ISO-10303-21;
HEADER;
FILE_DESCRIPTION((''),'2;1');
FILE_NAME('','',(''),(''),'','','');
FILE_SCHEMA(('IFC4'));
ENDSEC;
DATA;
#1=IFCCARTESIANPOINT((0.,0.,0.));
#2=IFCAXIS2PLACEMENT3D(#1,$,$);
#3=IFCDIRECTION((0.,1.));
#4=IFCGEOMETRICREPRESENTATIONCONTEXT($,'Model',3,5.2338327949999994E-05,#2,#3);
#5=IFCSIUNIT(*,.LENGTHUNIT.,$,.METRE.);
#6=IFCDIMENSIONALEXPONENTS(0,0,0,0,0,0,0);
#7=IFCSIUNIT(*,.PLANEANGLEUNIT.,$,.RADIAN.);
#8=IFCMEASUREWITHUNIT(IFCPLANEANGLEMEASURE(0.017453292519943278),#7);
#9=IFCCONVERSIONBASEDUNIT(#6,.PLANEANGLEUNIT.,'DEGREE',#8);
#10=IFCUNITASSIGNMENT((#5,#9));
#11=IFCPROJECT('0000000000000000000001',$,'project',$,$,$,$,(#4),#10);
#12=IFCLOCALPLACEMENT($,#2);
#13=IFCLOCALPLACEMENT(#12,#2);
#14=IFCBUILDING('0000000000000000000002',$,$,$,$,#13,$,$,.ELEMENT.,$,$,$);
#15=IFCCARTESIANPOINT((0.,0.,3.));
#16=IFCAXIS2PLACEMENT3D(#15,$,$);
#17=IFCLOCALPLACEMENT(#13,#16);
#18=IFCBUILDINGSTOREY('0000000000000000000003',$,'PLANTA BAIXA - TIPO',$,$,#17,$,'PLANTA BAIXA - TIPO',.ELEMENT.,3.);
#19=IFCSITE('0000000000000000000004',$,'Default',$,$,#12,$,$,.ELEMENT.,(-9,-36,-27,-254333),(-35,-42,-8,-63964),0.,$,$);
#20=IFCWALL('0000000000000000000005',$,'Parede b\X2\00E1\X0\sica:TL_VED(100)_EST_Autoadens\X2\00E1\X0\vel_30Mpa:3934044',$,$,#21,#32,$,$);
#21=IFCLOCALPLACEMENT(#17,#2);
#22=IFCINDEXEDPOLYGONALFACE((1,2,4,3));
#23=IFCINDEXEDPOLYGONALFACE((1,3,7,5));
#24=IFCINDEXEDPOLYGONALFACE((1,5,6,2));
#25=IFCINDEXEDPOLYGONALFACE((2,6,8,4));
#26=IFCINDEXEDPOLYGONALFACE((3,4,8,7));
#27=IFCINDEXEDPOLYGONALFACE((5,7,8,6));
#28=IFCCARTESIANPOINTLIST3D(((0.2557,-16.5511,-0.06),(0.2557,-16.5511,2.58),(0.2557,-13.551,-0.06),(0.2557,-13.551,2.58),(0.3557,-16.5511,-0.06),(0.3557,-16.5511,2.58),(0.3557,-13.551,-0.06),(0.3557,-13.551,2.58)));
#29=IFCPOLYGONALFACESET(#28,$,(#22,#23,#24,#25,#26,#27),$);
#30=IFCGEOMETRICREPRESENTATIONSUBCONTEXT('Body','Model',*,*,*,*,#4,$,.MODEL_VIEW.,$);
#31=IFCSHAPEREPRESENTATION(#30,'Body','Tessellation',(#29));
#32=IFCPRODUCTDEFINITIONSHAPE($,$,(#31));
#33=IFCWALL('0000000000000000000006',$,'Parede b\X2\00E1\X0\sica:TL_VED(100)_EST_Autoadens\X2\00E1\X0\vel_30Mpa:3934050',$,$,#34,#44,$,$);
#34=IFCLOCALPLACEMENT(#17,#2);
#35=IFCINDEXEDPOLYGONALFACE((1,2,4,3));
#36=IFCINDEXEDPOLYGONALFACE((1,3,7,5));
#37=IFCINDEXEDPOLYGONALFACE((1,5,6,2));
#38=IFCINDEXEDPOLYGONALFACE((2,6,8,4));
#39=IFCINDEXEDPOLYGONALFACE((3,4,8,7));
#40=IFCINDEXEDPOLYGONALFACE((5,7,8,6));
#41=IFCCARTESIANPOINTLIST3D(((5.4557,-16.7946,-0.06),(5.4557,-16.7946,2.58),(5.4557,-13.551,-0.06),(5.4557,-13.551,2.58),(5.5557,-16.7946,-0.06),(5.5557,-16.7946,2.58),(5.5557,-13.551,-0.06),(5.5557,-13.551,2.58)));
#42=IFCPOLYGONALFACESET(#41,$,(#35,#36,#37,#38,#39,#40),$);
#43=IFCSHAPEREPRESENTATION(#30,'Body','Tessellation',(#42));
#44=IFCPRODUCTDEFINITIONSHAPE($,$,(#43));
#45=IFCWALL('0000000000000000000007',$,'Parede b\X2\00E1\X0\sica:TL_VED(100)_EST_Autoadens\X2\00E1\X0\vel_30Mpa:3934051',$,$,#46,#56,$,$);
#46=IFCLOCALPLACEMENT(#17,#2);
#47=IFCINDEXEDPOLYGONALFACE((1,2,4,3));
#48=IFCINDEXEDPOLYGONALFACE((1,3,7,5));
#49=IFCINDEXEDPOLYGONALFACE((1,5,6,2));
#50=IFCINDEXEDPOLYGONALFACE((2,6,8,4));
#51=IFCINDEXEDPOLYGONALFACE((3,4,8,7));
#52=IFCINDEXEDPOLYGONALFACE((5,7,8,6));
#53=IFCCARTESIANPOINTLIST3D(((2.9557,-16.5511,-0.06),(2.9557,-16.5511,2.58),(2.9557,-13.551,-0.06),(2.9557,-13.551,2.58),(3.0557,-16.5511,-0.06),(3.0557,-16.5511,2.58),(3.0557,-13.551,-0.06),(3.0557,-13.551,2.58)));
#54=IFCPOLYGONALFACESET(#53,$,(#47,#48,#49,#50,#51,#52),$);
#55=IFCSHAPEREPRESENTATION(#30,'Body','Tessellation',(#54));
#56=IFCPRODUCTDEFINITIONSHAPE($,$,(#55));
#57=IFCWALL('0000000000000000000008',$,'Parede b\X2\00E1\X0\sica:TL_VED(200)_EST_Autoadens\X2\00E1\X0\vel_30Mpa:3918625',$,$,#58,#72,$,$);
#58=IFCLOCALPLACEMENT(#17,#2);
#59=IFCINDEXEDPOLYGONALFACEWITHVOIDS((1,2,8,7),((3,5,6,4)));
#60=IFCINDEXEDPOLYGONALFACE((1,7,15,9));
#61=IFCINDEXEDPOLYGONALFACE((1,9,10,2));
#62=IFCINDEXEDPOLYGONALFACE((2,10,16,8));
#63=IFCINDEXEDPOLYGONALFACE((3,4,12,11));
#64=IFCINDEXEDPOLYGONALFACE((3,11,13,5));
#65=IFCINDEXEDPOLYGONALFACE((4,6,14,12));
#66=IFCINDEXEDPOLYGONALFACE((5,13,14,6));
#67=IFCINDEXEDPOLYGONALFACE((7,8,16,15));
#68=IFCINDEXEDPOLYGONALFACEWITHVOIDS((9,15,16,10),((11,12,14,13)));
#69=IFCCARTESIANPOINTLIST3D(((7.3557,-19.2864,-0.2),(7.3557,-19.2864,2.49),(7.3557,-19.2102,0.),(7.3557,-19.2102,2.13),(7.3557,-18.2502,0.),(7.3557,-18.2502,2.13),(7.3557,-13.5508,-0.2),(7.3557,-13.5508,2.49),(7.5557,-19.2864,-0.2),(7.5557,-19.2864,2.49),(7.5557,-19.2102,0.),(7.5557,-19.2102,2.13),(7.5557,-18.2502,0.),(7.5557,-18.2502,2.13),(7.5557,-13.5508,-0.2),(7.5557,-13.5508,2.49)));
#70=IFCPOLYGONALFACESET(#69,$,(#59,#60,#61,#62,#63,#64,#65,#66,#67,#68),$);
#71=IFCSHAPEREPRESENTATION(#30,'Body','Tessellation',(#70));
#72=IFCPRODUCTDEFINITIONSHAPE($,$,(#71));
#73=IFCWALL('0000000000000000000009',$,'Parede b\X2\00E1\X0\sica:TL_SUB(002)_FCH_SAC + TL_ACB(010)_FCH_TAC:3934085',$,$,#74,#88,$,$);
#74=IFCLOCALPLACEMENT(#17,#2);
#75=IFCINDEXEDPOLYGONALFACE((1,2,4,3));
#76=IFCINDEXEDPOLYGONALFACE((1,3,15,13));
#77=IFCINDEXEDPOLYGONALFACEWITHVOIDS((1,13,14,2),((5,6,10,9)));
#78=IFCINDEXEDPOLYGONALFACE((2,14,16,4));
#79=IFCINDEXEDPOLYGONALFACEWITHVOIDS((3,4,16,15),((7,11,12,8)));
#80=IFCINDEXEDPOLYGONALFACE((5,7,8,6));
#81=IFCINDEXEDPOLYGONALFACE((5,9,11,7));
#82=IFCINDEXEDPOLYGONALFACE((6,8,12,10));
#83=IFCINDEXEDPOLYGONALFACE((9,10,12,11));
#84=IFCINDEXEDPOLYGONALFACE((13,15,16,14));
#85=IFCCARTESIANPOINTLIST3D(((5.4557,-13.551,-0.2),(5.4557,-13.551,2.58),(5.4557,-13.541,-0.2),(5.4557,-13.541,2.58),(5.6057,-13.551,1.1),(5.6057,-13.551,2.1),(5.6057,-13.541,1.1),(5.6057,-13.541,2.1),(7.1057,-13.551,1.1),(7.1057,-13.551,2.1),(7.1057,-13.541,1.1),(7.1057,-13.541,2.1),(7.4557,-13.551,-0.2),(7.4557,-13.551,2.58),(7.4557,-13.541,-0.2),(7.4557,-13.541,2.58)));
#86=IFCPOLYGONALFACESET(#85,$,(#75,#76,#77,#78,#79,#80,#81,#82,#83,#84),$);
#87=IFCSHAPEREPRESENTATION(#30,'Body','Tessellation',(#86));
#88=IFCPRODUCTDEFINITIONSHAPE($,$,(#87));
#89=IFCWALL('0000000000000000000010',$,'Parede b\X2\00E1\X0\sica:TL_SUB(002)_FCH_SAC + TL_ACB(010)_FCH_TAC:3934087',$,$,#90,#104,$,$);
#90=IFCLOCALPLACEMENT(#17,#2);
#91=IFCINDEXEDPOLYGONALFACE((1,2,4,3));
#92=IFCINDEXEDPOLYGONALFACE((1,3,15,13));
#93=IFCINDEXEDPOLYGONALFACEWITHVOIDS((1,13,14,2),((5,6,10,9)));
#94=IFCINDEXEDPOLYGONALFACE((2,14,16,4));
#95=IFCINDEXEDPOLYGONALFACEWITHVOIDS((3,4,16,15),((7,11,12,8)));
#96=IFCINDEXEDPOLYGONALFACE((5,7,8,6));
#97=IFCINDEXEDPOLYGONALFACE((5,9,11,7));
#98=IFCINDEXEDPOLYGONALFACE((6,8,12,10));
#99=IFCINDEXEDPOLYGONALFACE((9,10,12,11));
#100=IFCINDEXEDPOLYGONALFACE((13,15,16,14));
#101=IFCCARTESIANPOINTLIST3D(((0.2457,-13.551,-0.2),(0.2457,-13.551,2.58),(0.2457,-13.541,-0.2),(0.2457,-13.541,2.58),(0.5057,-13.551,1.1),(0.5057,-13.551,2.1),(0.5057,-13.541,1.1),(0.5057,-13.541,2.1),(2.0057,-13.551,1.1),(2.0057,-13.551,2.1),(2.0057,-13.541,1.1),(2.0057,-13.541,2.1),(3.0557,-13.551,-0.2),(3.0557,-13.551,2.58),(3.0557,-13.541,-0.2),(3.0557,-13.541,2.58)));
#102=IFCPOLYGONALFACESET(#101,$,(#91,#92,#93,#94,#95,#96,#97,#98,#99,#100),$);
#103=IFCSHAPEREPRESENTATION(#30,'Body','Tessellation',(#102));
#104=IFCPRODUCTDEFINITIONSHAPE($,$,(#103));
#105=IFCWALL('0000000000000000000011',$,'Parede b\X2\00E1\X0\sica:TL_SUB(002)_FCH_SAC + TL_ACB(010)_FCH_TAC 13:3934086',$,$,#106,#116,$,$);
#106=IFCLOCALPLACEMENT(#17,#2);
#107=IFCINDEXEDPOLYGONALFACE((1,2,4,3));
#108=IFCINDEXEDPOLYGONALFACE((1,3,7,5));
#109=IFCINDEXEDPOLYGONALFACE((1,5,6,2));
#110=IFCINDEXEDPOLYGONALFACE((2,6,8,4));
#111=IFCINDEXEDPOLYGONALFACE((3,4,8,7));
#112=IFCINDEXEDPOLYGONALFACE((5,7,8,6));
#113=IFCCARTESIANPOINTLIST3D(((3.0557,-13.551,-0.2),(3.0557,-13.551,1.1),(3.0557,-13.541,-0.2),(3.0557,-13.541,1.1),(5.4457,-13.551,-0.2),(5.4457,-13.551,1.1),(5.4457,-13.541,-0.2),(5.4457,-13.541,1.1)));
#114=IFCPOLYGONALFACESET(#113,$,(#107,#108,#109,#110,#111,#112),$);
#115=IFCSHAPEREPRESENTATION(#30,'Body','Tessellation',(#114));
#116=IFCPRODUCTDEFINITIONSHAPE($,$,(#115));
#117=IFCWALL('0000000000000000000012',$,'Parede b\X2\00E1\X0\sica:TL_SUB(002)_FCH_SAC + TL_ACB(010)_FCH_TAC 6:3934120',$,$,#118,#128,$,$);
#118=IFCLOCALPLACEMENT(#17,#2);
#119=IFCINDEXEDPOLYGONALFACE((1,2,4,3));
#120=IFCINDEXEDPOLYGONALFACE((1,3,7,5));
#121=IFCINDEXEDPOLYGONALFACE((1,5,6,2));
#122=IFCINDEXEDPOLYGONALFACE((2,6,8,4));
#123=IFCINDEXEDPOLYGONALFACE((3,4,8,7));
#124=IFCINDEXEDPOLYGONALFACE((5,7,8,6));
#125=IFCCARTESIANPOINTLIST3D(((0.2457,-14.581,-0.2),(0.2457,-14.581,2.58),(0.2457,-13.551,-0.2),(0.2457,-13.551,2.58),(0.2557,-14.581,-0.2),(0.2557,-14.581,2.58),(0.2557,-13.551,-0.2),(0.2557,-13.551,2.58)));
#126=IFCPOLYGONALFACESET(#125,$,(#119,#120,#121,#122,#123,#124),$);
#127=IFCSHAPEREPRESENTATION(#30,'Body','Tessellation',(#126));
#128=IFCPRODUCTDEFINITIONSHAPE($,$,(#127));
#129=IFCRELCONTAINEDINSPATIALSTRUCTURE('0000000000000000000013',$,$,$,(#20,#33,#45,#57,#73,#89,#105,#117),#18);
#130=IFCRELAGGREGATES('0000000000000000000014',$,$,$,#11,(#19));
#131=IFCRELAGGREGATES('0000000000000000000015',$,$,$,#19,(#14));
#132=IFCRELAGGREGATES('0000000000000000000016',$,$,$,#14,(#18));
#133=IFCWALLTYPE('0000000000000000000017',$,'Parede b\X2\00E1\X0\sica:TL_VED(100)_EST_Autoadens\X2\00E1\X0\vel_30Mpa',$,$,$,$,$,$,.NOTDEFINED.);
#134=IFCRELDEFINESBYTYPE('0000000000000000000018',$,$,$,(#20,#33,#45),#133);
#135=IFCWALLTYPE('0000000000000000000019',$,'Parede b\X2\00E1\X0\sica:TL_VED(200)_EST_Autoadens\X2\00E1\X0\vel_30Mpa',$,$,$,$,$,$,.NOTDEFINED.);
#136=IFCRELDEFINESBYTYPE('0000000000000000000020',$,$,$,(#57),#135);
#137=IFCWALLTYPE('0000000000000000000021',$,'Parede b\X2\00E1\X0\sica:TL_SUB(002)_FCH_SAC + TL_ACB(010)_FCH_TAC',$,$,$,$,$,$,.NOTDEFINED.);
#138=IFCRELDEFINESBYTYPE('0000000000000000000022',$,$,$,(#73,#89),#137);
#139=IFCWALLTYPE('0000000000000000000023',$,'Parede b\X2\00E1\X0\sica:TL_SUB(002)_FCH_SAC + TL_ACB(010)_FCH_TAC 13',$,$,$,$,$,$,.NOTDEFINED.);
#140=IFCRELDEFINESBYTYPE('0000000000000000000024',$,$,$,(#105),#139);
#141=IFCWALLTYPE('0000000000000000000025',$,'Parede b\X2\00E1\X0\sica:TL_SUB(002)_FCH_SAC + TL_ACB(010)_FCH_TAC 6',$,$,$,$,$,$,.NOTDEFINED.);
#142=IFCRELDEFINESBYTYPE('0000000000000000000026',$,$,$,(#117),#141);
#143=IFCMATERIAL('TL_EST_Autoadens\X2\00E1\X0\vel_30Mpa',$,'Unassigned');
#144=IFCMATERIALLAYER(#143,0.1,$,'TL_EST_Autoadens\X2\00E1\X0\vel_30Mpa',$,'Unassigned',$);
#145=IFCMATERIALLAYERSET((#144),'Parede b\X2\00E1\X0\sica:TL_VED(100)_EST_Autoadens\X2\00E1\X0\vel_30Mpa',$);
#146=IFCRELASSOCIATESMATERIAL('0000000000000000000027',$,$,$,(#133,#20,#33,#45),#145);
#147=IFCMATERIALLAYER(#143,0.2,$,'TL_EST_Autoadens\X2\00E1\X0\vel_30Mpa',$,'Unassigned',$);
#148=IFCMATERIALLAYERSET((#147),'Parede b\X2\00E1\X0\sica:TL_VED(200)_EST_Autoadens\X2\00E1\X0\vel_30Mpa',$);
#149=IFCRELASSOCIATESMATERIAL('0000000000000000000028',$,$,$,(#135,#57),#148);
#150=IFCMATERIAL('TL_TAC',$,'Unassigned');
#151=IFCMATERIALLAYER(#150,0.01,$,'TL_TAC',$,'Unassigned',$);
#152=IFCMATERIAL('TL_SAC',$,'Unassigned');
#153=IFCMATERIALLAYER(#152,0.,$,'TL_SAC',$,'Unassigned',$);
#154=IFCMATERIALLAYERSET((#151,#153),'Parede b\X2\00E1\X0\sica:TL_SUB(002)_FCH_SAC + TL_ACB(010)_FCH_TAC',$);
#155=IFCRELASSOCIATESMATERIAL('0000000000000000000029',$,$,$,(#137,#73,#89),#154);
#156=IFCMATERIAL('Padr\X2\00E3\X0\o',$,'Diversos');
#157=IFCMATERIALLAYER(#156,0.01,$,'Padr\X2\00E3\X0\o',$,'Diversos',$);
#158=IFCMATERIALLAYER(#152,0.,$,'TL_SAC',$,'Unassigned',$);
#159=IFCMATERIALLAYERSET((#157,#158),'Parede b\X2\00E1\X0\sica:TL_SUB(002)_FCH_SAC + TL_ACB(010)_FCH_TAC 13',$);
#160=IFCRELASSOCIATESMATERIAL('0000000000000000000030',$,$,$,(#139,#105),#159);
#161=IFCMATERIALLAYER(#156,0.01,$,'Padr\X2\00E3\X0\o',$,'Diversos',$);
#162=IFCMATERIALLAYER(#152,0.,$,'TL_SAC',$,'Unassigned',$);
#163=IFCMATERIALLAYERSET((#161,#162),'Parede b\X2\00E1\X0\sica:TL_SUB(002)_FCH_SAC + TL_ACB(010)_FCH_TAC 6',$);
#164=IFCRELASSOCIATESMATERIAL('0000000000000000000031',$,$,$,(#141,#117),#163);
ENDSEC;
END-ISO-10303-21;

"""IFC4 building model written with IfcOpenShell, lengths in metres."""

from ifc_helpers import new_model, entity, si_unit, converted_unit, direction, frame, frame_2d, origin, place, context, subcontext, project, spatial, rectangle, extrude, material, layer, layer_set, layer_usage, type_object, element, save


model = new_model("IFC4")

# Units and contexts
model_context = context("Model", 3, precision=5.2338327949999994e-05, world=origin(), true_north=direction((0.0, 1.0)))
body_context = subcontext(model_context, "Body", "Model", "MODEL_VIEW")
ifc_project = project(units=[si_unit("LENGTHUNIT", "METRE"), converted_unit("PLANEANGLEUNIT", "DEGREE", entity("IfcPlaneAngleMeasure", 0.017453292519943278), si_unit("PLANEANGLEUNIT", "RADIAN"), dimensions=[0, 0, 0, 0, 0, 0, 0])], contexts=[model_context])

# Site, building, storey
site_placement = place(None, frame((0.0, 0.0, 0.0)))
site = spatial("IfcSite", under=ifc_project, at=site_placement, Name="Default", CompositionType="ELEMENT", RefLatitude=(-9, -36, -27, -254333), RefLongitude=(-35, -42, -8, -63964), RefElevation=0.0)
building_placement = place(site_placement, origin())
building = spatial("IfcBuilding", under=site, at=building_placement, CompositionType="ELEMENT")
storey_placement = place(building_placement, frame((0.0, 0.0, 3.0)))
storey = spatial("IfcBuildingStorey", under=building, at=storey_placement, Name="PLANTA BAIXA - TIPO", LongName="PLANTA BAIXA - TIPO", CompositionType="ELEMENT", Elevation=3.0)

# Walls
ifc_material_1 = material(Name="TL_EST_Autoadensável_30Mpa", Category="Unassigned")
ifc_layer_1 = layer(ifc_material_1, 0.1, Name="TL_EST_Autoadensável_30Mpa", Category="Unassigned")
ifc_layer_set_1 = layer_set([ifc_layer_1], Name="Parede básica:TL_VED(100)_EST_Autoadensável_30Mpa")
ifc_layer_usage_1 = layer_usage(ifc_layer_set_1, "AXIS2", "NEGATIVE", 0.05)
wall_type_1 = type_object("IfcWallType", Name="Parede básica:TL_VED(100)_EST_Autoadensável_30Mpa", PredefinedType="NOTDEFINED", material=ifc_layer_set_1)
wall_1_placement = place(storey_placement, frame((0.3057, -13.551, -0.06), z_axis=(0.0, 0.0, 1.0), x_axis=(0.0, -1.0, 0.0)))
element("IfcWall", 1, at=wall_1_placement, inside=storey, type_object=wall_type_1, material=ifc_layer_usage_1, Name="Parede básica:TL_VED(100)_EST_Autoadensável_30Mpa:3934044", context=body_context, shape_type="SweptSolid", body=[
    extrude(rectangle(XDim=3.0001, YDim=0.1, at=frame_2d((1.5001, 0.0), x_axis=(-1.0, 0.0))), origin(), (0.0, 0.0, 1.0), 2.64),
])
ifc_layer_usage_2 = layer_usage(ifc_layer_set_1, "AXIS2", "NEGATIVE", 0.05)
wall_2_placement = place(storey_placement, frame((5.5057, -13.551, -0.06), z_axis=(0.0, 0.0, 1.0), x_axis=(0.0, -1.0, 0.0)))
element("IfcWall", 2, at=wall_2_placement, inside=storey, type_object=wall_type_1, material=ifc_layer_usage_2, Name="Parede básica:TL_VED(100)_EST_Autoadensável_30Mpa:3934050", context=body_context, shape_type="SweptSolid", body=[
    extrude(rectangle(XDim=3.2437, YDim=0.1, at=frame_2d((1.6218, 0.0), x_axis=(-1.0, 0.0))), origin(), (0.0, 0.0, 1.0), 2.64),
])

# Walls, openings
ifc_layer_usage_3 = layer_usage(ifc_layer_set_1, "AXIS2", "NEGATIVE", 0.05)
wall_3_placement = place(storey_placement, frame((3.0057, -13.551, -0.06), z_axis=(0.0, 0.0, 1.0), x_axis=(0.0, -1.0, 0.0)))
wall_3 = element("IfcWall", 3, at=wall_3_placement, inside=storey, type_object=wall_type_1, material=ifc_layer_usage_3, Name="Parede básica:TL_VED(100)_EST_Autoadensável_30Mpa:3934051", context=body_context, shape_type="SweptSolid", body=[
    extrude(rectangle(XDim=3.0001, YDim=0.1, at=frame_2d((1.5001, 0.0), x_axis=(-1.0, 0.0))), origin(), (0.0, 0.0, 1.0), 2.64),
])
opening_1_placement = place(wall_3_placement, frame((-13.551, -3.0057, 0.06)))
element("IfcOpeningElement", 4, at=opening_1_placement, cuts=wall_3, PredefinedType="OPENING", context=body_context, shape_type="SweptSolid", body=[
    extrude(rectangle(XDim=2.1, YDim=0.1, at=frame_2d((0.0, 0.0), x_axis=(0.0, 1.0))), frame((14.501, 3.0557, 1.05), z_axis=(0.0, 1.0, 0.0), x_axis=(1.0, 0.0, 0.0)), (0.0, 0.0, 1.0), 2.4),
])
ifc_layer_2 = layer(ifc_material_1, 0.2, Name="TL_EST_Autoadensável_30Mpa", Category="Unassigned")
ifc_layer_set_2 = layer_set([ifc_layer_2], Name="Parede básica:TL_VED(200)_EST_Autoadensável_30Mpa")
ifc_layer_usage_4 = layer_usage(ifc_layer_set_2, "AXIS2", "NEGATIVE", 0.1)
wall_type_2 = type_object("IfcWallType", Name="Parede básica:TL_VED(200)_EST_Autoadensável_30Mpa", PredefinedType="NOTDEFINED", material=ifc_layer_set_2)
wall_4_placement = place(storey_placement, frame((7.4557, -13.5508, -0.2), z_axis=(0.0, 0.0, 1.0), x_axis=(0.0, -1.0, 0.0)))
wall_4 = element("IfcWall", 5, at=wall_4_placement, inside=storey, type_object=wall_type_2, material=ifc_layer_usage_4, Name="Parede básica:TL_VED(200)_EST_Autoadensável_30Mpa:3918625", context=body_context, shape_type="SweptSolid", body=[
    extrude(rectangle(XDim=5.7355, YDim=0.2, at=frame_2d((2.8678, 0.0), x_axis=(-1.0, 0.0))), origin(), (0.0, 0.0, 1.0), 2.69),
])
opening_2_placement = place(wall_4_placement, frame((5.6593, 0.1, 0.2)))
element("IfcOpeningElement", 6, at=opening_2_placement, cuts=wall_4, PredefinedType="OPENING", context=body_context, shape_type="SweptSolid", body=[
    extrude(rectangle(XDim=2.13, YDim=0.96, at=frame_2d((1.065, 0.48), x_axis=(1.0, 0.0))), frame((0.0, 0.0, 0.0), z_axis=(0.0, -1.0, 0.0), x_axis=(0.0, 0.0, 1.0)), (0.0, 0.0, 1.0), 0.2),
])
ifc_material_2 = material(Name="TL_TAC", Category="Unassigned")
ifc_layer_3 = layer(ifc_material_2, 0.01, Name="TL_TAC", Category="Unassigned")
ifc_material_3 = material(Name="TL_SAC", Category="Unassigned")
ifc_layer_4 = layer(ifc_material_3, 0.0, Name="TL_SAC", Category="Unassigned")
ifc_layer_set_3 = layer_set([ifc_layer_3, ifc_layer_4], Name="Parede básica:TL_SUB(002)_FCH_SAC + TL_ACB(010)_FCH_TAC")
ifc_layer_usage_5 = layer_usage(ifc_layer_set_3, "AXIS2", "NEGATIVE", 0.005)
wall_type_3 = type_object("IfcWallType", Name="Parede básica:TL_SUB(002)_FCH_SAC + TL_ACB(010)_FCH_TAC", PredefinedType="NOTDEFINED", material=ifc_layer_set_3)
wall_5_placement = place(storey_placement, frame((7.4557, -13.546, -0.2), z_axis=(0.0, 0.0, 1.0), x_axis=(-1.0, 0.0, 0.0)))
wall_5 = element("IfcWall", 7, at=wall_5_placement, inside=storey, type_object=wall_type_3, material=ifc_layer_usage_5, Name="Parede básica:TL_SUB(002)_FCH_SAC + TL_ACB(010)_FCH_TAC:3934085", context=body_context, shape_type="SweptSolid", body=[
    extrude(rectangle(XDim=2.0, YDim=0.01, at=frame_2d((1.0, 0.0), x_axis=(-1.0, 0.0))), origin(), (0.0, 0.0, 1.0), 2.78),
])
opening_3_placement = place(wall_5_placement, frame((7.4557, -13.546, 1.3)))
element("IfcOpeningElement", 8, at=opening_3_placement, cuts=wall_5, PredefinedType="OPENING", context=body_context, shape_type="SweptSolid", body=[
    extrude(rectangle(XDim=1.0, YDim=1.5, at=frame_2d((0.0, 0.0), x_axis=(0.0, 1.0))), frame((-6.3557, 12.127, 0.5), z_axis=(0.0, 1.0, 0.0), x_axis=(1.0, 0.0, 0.0)), (0.0, 0.0, 1.0), 3.048),
])
ifc_layer_usage_6 = layer_usage(ifc_layer_set_3, "AXIS2", "POSITIVE", -0.005)
wall_6_placement = place(storey_placement, frame((3.0557, -13.546, -0.2), z_axis=(0.0, 0.0, 1.0), x_axis=(-1.0, 0.0, 0.0)))
wall_6 = element("IfcWall", 9, at=wall_6_placement, inside=storey, type_object=wall_type_3, material=ifc_layer_usage_6, Name="Parede básica:TL_SUB(002)_FCH_SAC + TL_ACB(010)_FCH_TAC:3934087", context=body_context, shape_type="SweptSolid", body=[
    extrude(rectangle(XDim=2.81, YDim=0.01, at=frame_2d((1.405, 0.0), x_axis=(-1.0, 0.0))), origin(), (0.0, 0.0, 1.0), 2.78),
])
opening_4_placement = place(wall_6_placement, frame((3.0557, -13.546, 1.3)))
element("IfcOpeningElement", 10, at=opening_4_placement, cuts=wall_6, PredefinedType="OPENING", context=body_context, shape_type="SweptSolid", body=[
    extrude(rectangle(XDim=1.0, YDim=1.5, at=frame_2d((0.0, 0.0), x_axis=(0.0, 1.0))), frame((-1.2557, 12.127, 0.5), z_axis=(0.0, 1.0, 0.0), x_axis=(1.0, 0.0, 0.0)), (0.0, 0.0, 1.0), 3.048),
])

# Walls
ifc_material_4 = material(Name="Padrão", Category="Diversos")
ifc_layer_5 = layer(ifc_material_4, 0.01, Name="Padrão", Category="Diversos")
ifc_layer_6 = layer(ifc_material_3, 0.0, Name="TL_SAC", Category="Unassigned")
ifc_layer_set_4 = layer_set([ifc_layer_5, ifc_layer_6], Name="Parede básica:TL_SUB(002)_FCH_SAC + TL_ACB(010)_FCH_TAC 13")
ifc_layer_usage_7 = layer_usage(ifc_layer_set_4, "AXIS2", "NEGATIVE", 0.005)
wall_type_4 = type_object("IfcWallType", Name="Parede básica:TL_SUB(002)_FCH_SAC + TL_ACB(010)_FCH_TAC 13", PredefinedType="NOTDEFINED", material=ifc_layer_set_4)
wall_7_placement = place(storey_placement, frame((5.4457, -13.546, -0.2), z_axis=(0.0, 0.0, 1.0), x_axis=(-1.0, 0.0, 0.0)))
element("IfcWall", 11, at=wall_7_placement, inside=storey, type_object=wall_type_4, material=ifc_layer_usage_7, Name="Parede básica:TL_SUB(002)_FCH_SAC + TL_ACB(010)_FCH_TAC 13:3934086", context=body_context, shape_type="SweptSolid", body=[
    extrude(rectangle(XDim=2.39, YDim=0.01, at=frame_2d((1.195, 0.0), x_axis=(-1.0, 0.0))), origin(), (0.0, 0.0, 1.0), 1.3),
])
ifc_layer_7 = layer(ifc_material_4, 0.01, Name="Padrão", Category="Diversos")
ifc_layer_8 = layer(ifc_material_3, 0.0, Name="TL_SAC", Category="Unassigned")
ifc_layer_set_5 = layer_set([ifc_layer_7, ifc_layer_8], Name="Parede básica:TL_SUB(002)_FCH_SAC + TL_ACB(010)_FCH_TAC 6")
ifc_layer_usage_8 = layer_usage(ifc_layer_set_5, "AXIS2", "NEGATIVE", 0.005)
wall_type_5 = type_object("IfcWallType", Name="Parede básica:TL_SUB(002)_FCH_SAC + TL_ACB(010)_FCH_TAC 6", PredefinedType="NOTDEFINED", material=ifc_layer_set_5)
wall_8_placement = place(storey_placement, frame((0.2507, -13.551, -0.2), z_axis=(0.0, 0.0, 1.0), x_axis=(0.0, -1.0, 0.0)))
element("IfcWall", 12, at=wall_8_placement, inside=storey, type_object=wall_type_5, material=ifc_layer_usage_8, Name="Parede básica:TL_SUB(002)_FCH_SAC + TL_ACB(010)_FCH_TAC 6:3934120", context=body_context, shape_type="SweptSolid", body=[
    extrude(rectangle(XDim=1.03, YDim=0.01, at=frame_2d((0.515, 0.0), x_axis=(-1.0, 0.0))), origin(), (0.0, 0.0, 1.0), 2.78),
])

save(model, "model.ifc")
